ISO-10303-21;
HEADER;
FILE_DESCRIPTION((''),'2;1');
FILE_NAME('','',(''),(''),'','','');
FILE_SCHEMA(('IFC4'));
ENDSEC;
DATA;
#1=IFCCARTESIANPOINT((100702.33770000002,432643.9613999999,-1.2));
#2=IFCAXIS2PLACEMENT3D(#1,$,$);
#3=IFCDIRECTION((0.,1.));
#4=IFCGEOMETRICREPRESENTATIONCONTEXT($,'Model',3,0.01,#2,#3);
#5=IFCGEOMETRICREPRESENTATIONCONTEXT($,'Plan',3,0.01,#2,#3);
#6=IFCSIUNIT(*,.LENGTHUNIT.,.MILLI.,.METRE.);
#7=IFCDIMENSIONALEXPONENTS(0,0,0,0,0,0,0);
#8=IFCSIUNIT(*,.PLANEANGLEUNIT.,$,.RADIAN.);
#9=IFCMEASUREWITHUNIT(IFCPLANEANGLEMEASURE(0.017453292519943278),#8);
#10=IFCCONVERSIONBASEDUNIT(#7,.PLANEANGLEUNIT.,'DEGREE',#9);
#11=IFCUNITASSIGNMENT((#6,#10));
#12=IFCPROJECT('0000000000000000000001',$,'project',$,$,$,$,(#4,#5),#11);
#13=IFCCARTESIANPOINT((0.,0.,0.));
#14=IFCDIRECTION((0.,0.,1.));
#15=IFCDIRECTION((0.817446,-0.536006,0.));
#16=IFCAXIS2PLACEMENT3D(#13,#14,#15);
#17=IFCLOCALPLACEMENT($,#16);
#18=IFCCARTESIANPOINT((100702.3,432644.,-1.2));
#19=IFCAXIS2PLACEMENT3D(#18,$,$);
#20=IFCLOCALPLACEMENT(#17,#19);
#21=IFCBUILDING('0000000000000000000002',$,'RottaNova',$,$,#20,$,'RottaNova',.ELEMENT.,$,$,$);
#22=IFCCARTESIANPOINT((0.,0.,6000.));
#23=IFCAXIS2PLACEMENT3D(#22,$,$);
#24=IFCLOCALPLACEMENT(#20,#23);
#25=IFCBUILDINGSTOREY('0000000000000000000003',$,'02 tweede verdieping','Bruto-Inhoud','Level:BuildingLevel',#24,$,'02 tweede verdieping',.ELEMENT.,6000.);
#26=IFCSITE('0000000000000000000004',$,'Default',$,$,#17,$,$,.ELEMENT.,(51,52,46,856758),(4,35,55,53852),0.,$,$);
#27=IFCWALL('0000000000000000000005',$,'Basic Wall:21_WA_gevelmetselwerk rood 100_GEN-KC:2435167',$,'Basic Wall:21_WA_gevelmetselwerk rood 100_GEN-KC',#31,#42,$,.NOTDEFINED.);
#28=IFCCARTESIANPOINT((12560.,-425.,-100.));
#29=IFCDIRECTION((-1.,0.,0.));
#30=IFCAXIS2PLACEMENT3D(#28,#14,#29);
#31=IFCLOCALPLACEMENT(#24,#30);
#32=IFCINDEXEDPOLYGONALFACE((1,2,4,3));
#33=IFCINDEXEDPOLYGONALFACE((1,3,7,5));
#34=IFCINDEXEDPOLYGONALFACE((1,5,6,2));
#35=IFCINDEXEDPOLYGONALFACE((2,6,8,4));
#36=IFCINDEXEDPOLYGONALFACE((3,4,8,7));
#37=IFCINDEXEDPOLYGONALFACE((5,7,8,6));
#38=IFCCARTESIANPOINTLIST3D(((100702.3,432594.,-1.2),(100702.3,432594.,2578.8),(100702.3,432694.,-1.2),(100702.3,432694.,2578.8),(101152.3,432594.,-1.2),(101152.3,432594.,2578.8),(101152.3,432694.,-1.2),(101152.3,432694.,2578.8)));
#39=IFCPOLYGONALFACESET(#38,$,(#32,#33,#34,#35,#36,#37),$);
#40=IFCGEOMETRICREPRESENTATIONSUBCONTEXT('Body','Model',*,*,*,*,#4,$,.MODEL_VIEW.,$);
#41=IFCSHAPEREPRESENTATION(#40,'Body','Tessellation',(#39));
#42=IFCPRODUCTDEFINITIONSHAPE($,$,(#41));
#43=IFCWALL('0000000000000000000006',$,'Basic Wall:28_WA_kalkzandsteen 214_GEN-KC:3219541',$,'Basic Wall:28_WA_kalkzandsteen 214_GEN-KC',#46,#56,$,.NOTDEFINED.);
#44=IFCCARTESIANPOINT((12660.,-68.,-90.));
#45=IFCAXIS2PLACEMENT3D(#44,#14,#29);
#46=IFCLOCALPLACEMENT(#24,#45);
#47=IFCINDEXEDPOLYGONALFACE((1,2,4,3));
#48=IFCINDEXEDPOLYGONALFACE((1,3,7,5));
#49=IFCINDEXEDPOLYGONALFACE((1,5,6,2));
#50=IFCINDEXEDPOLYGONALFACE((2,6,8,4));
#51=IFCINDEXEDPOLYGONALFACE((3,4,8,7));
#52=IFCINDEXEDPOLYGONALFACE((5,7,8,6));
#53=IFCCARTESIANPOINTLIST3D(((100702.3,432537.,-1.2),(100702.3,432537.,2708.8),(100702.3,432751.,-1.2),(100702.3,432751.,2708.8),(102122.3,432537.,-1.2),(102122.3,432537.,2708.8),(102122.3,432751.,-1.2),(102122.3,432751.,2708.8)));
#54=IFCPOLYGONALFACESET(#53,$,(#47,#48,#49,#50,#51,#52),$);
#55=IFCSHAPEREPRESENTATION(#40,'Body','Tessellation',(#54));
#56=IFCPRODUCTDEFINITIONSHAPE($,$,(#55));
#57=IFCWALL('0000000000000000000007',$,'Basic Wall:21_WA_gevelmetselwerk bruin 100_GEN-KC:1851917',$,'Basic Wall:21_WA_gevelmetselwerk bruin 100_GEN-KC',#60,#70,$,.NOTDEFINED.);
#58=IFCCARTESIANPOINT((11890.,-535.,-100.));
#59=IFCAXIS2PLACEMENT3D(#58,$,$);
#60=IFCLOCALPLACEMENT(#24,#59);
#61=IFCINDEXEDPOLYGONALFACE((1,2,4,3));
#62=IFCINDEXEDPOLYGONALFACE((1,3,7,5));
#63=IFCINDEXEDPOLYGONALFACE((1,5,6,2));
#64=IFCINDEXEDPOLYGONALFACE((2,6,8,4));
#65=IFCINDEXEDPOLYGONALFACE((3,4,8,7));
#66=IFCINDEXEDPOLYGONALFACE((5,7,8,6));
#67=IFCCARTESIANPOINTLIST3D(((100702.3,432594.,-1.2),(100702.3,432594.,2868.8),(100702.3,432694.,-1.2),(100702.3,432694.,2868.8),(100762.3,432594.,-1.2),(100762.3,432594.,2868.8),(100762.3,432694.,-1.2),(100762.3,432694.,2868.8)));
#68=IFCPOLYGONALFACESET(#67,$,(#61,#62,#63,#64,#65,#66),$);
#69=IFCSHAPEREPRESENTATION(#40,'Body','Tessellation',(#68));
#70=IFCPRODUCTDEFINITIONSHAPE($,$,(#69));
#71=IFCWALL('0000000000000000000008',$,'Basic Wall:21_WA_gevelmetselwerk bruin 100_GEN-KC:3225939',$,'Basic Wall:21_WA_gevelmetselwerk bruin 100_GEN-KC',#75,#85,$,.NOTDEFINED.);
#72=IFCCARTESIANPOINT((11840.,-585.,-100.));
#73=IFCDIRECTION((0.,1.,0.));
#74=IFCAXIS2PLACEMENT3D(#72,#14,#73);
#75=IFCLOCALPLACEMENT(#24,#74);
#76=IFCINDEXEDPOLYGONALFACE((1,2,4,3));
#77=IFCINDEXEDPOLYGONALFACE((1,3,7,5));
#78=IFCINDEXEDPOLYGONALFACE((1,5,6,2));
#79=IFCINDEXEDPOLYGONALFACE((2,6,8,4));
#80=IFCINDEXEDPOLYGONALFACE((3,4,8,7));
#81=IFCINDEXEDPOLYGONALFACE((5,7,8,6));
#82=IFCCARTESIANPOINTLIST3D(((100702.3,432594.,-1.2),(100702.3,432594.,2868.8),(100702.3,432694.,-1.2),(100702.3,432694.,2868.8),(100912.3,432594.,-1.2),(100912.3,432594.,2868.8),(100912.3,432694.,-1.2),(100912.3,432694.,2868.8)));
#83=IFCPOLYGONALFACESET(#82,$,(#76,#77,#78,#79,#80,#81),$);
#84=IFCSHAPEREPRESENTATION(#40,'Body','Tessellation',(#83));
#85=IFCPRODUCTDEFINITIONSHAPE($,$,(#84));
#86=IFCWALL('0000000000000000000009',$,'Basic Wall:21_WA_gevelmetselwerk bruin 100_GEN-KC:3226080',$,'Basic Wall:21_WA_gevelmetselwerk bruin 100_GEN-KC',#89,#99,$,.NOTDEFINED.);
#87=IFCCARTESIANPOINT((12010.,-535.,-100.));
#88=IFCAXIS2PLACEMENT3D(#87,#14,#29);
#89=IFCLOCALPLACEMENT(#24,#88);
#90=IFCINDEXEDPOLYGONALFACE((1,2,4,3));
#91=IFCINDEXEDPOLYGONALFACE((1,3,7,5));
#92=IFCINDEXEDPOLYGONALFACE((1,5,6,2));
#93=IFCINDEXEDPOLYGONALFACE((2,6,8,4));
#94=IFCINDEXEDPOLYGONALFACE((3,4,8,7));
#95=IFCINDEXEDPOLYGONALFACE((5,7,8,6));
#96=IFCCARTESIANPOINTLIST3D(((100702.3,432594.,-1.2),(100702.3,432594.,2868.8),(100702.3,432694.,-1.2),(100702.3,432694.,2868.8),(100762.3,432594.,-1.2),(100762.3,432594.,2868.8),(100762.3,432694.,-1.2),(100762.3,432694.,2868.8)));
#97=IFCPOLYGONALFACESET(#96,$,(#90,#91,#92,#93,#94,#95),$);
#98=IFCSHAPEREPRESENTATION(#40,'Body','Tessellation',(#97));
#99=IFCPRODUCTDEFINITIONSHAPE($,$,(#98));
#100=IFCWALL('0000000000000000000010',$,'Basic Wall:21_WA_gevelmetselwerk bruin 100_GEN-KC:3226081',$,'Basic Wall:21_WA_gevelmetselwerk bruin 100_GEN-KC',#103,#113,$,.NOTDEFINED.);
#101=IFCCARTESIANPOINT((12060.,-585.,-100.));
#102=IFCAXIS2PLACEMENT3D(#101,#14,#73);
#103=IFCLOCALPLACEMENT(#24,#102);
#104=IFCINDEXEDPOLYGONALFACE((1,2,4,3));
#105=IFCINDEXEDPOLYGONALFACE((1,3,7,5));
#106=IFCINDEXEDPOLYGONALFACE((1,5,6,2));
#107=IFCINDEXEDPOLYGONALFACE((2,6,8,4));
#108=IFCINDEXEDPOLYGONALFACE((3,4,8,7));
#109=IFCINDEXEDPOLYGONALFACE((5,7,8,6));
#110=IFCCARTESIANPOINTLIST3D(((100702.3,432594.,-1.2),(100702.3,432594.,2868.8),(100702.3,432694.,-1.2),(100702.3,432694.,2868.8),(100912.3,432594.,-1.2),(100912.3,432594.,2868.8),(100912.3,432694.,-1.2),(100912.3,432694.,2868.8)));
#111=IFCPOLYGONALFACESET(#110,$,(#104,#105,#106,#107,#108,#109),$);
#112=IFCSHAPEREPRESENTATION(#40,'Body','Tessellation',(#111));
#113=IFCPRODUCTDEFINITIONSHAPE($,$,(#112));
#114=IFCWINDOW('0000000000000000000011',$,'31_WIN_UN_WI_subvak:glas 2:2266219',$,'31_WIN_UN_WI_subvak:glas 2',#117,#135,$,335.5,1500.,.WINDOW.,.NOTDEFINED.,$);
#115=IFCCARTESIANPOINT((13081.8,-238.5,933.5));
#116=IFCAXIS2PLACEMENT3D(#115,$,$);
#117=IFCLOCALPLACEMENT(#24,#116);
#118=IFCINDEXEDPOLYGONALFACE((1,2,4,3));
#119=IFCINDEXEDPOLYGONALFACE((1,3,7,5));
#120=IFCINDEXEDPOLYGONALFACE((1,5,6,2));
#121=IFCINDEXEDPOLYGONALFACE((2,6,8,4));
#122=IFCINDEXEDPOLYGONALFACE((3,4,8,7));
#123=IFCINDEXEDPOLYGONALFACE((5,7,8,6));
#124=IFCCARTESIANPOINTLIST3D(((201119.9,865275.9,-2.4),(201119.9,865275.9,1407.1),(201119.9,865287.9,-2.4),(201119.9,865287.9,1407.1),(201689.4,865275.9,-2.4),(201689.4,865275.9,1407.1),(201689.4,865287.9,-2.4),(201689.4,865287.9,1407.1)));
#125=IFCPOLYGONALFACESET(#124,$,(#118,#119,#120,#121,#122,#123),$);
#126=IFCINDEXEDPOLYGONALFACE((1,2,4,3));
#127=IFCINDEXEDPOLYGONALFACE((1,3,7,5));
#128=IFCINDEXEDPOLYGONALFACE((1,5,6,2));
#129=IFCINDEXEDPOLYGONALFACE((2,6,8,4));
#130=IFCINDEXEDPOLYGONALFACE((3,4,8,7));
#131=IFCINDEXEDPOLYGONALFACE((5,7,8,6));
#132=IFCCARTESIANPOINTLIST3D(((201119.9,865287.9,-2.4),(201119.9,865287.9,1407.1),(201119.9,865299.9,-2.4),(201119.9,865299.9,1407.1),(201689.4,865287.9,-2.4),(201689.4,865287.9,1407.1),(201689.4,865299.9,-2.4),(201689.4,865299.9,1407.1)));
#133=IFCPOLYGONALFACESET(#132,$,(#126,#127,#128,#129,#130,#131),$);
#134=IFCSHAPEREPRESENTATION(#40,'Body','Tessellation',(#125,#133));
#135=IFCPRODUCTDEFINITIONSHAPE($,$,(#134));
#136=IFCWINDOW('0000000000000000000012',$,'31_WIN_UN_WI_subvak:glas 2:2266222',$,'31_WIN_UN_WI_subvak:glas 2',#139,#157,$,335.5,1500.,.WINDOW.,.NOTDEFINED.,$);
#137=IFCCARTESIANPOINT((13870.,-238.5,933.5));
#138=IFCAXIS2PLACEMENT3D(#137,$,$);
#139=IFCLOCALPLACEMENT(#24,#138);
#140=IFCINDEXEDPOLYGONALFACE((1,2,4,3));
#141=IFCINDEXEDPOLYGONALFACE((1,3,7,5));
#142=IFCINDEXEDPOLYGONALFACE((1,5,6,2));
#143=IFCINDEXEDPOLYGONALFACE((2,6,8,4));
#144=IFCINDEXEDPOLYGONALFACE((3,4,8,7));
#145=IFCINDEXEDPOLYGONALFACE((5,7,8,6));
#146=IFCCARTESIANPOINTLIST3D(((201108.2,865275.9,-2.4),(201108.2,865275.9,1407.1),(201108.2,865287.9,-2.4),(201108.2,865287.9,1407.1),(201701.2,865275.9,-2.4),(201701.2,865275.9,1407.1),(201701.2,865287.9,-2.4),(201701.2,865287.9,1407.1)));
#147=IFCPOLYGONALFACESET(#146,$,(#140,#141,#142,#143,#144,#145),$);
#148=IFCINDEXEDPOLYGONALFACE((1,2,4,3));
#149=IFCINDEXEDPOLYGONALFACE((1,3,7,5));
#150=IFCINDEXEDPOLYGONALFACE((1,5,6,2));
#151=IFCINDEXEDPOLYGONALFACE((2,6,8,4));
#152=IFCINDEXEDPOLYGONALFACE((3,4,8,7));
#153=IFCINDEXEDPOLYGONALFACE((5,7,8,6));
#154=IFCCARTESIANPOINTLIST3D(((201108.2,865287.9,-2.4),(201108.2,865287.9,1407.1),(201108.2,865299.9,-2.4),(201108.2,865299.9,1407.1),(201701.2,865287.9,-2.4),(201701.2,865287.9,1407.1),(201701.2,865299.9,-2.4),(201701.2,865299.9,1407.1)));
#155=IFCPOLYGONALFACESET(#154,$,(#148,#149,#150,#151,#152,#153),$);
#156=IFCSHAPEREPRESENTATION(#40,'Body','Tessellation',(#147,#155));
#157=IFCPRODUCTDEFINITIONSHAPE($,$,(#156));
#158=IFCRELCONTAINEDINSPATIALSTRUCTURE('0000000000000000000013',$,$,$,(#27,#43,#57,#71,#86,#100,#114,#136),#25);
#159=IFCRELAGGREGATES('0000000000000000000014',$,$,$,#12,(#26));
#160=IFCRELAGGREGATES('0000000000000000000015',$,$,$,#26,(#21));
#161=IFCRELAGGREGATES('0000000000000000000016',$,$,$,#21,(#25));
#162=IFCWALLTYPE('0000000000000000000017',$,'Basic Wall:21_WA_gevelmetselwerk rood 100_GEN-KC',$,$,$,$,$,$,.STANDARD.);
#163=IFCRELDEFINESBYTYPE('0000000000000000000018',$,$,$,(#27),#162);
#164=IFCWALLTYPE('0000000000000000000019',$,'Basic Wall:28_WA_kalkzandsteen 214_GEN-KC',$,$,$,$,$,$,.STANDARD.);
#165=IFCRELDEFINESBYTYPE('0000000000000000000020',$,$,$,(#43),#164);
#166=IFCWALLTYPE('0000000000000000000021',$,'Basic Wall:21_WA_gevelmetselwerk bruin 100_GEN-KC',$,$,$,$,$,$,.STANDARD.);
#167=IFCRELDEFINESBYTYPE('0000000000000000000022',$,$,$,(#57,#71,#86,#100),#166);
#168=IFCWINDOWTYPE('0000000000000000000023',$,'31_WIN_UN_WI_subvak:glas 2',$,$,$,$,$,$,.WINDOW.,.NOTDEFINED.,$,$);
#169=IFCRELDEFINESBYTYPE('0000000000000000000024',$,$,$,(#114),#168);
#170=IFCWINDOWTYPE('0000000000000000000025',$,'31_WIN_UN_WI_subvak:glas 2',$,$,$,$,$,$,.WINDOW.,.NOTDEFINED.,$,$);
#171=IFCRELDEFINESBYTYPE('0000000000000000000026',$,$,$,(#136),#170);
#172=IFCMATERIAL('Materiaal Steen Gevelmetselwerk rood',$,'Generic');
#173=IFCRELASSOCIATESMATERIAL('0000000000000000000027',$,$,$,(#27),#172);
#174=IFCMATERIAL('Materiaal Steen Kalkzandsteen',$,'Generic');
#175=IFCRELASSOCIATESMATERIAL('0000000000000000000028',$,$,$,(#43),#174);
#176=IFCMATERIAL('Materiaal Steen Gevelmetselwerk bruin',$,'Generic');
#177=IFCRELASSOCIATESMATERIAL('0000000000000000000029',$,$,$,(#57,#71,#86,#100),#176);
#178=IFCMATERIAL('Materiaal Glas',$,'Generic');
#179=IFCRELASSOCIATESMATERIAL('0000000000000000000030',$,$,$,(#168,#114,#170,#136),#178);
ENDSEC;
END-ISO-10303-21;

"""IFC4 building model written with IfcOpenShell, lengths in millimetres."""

from ifc_helpers import new_model, entity, si_unit, converted_unit, direction, frame, place, context, subcontext, project, spatial, indexed_curve, outline, extrude, source, transform, mapped, material, type_object, type_shapes, element, save


model = new_model("IFC4")

# Units and contexts
model_context = context("Model", 3, precision=0.01, world=frame((100702.33770000002, 432643.9613999999, -1.2)), true_north=direction((0.0, 1.0)))
plan_context = context("Plan", 3, precision=0.01, world=frame((100702.33770000002, 432643.9613999999, -1.2)), true_north=direction((0.0, 1.0)))
body_context = subcontext(model_context, "Body", "Model", "MODEL_VIEW")
ifc_project = project(units=[si_unit("LENGTHUNIT", "METRE", prefix="MILLI"), converted_unit("PLANEANGLEUNIT", "DEGREE", entity("IfcPlaneAngleMeasure", 0.017453292519943278), si_unit("PLANEANGLEUNIT", "RADIAN"), dimensions=[0, 0, 0, 0, 0, 0, 0])], contexts=[model_context, plan_context])

# Site, building, storey
site_placement = place(None, frame((0.0, 0.0, 0.0), z_axis=(0.0, 0.0, 1.0), x_axis=(0.817446, -0.536006, 0.0)))
site = spatial("IfcSite", under=ifc_project, at=site_placement, Name="Default", CompositionType="ELEMENT", RefLatitude=(51, 52, 46, 856758), RefLongitude=(4, 35, 55, 53852), RefElevation=0.0)
building_placement = place(site_placement, frame((100702.3, 432644.0, -1.2)))
building = spatial("IfcBuilding", under=site, at=building_placement, Name="RottaNova", LongName="RottaNova", CompositionType="ELEMENT")
storey_placement = place(building_placement, frame((0.0, 0.0, 6000.0)))
storey = spatial("IfcBuildingStorey", under=building, at=storey_placement, Name="02 tweede verdieping", Description="Bruto-Inhoud", ObjectType="Level:BuildingLevel", LongName="02 tweede verdieping", CompositionType="ELEMENT", Elevation=6000.0)

# Shared definitions
ifc_material_1 = material(Name="Materiaal Glas", Category="Generic")

# Walls
ifc_material_2 = material(Name="Materiaal Steen Gevelmetselwerk rood", Category="Generic")
wall_type_1 = type_object("IfcWallType", Name="Basic Wall:21_WA_gevelmetselwerk rood 100_GEN-KC", PredefinedType="STANDARD")
wall_1_placement = place(storey_placement, frame((12560.0, -425.0, -100.0), z_axis=(0.0, 0.0, 1.0), x_axis=(-1.0, 0.0, 0.0)))
element("IfcWall", 1, at=wall_1_placement, inside=storey, type_object=wall_type_1, material=ifc_material_2, Name="Basic Wall:21_WA_gevelmetselwerk rood 100_GEN-KC:2435167", ObjectType="Basic Wall:21_WA_gevelmetselwerk rood 100_GEN-KC", PredefinedType="NOTDEFINED", context=body_context, shape_type="SweptSolid", body=[
    extrude(outline(indexed_curve([(450.0, 50.0), (0.0, 50.0), (0.0, -50.0), (450.0, -50.0), (450.0, 50.0)], self_intersect=False)), frame((100702.3, 432644.0, -1.2)), (0.0, 0.0, 1.0), 2580.0),
])
ifc_material_3 = material(Name="Materiaal Steen Kalkzandsteen", Category="Generic")
wall_type_2 = type_object("IfcWallType", Name="Basic Wall:28_WA_kalkzandsteen 214_GEN-KC", PredefinedType="STANDARD")
wall_2_placement = place(storey_placement, frame((12660.0, -68.0, -90.0), z_axis=(0.0, 0.0, 1.0), x_axis=(-1.0, 0.0, 0.0)))
element("IfcWall", 2, at=wall_2_placement, inside=storey, type_object=wall_type_2, material=ifc_material_3, Name="Basic Wall:28_WA_kalkzandsteen 214_GEN-KC:3219541", ObjectType="Basic Wall:28_WA_kalkzandsteen 214_GEN-KC", PredefinedType="NOTDEFINED", context=body_context, shape_type="SweptSolid", body=[
    extrude(outline(indexed_curve([(1420.0, 107.0), (0.0, 107.0), (0.0, -107.0), (1420.0, -107.0), (1420.0, 107.0)], self_intersect=False)), frame((100702.3, 432644.0, -1.2)), (0.0, 0.0, 1.0), 2710.0),
])
ifc_material_4 = material(Name="Materiaal Steen Gevelmetselwerk bruin", Category="Generic")
wall_type_3 = type_object("IfcWallType", Name="Basic Wall:21_WA_gevelmetselwerk bruin 100_GEN-KC", PredefinedType="STANDARD")
wall_3_placement = place(storey_placement, frame((11890.0, -535.0, -100.0)))
element("IfcWall", 3, at=wall_3_placement, inside=storey, type_object=wall_type_3, material=ifc_material_4, Name="Basic Wall:21_WA_gevelmetselwerk bruin 100_GEN-KC:1851917", ObjectType="Basic Wall:21_WA_gevelmetselwerk bruin 100_GEN-KC", PredefinedType="NOTDEFINED", context=body_context, shape_type="SweptSolid", body=[
    extrude(outline(indexed_curve([(60.0, 50.0), (0.0, 50.0), (0.0, -50.0), (60.0, -50.0), (60.0, 50.0)], self_intersect=False)), frame((100702.3, 432644.0, -1.2)), (0.0, 0.0, 1.0), 2870.0),
])
wall_4_placement = place(storey_placement, frame((11840.0, -585.0, -100.0), z_axis=(0.0, 0.0, 1.0), x_axis=(0.0, 1.0, 0.0)))
element("IfcWall", 4, at=wall_4_placement, inside=storey, type_object=wall_type_3, material=ifc_material_4, Name="Basic Wall:21_WA_gevelmetselwerk bruin 100_GEN-KC:3225939", ObjectType="Basic Wall:21_WA_gevelmetselwerk bruin 100_GEN-KC", PredefinedType="NOTDEFINED", context=body_context, shape_type="SweptSolid", body=[
    extrude(outline(indexed_curve([(210.0, 50.0), (0.0, 50.0), (0.0, -50.0), (210.0, -50.0), (210.0, 50.0)], self_intersect=False)), frame((100702.3, 432644.0, -1.2)), (0.0, 0.0, 1.0), 2870.0),
])
wall_5_placement = place(storey_placement, frame((12010.0, -535.0, -100.0), z_axis=(0.0, 0.0, 1.0), x_axis=(-1.0, 0.0, 0.0)))
element("IfcWall", 5, at=wall_5_placement, inside=storey, type_object=wall_type_3, material=ifc_material_4, Name="Basic Wall:21_WA_gevelmetselwerk bruin 100_GEN-KC:3226080", ObjectType="Basic Wall:21_WA_gevelmetselwerk bruin 100_GEN-KC", PredefinedType="NOTDEFINED", context=body_context, shape_type="SweptSolid", body=[
    extrude(outline(indexed_curve([(60.0, 50.0), (0.0, 50.0), (0.0, -50.0), (60.0, -50.0), (60.0, 50.0)], self_intersect=False)), frame((100702.3, 432644.0, -1.2)), (0.0, 0.0, 1.0), 2870.0),
])
wall_6_placement = place(storey_placement, frame((12060.0, -585.0, -100.0), z_axis=(0.0, 0.0, 1.0), x_axis=(0.0, 1.0, 0.0)))
element("IfcWall", 6, at=wall_6_placement, inside=storey, type_object=wall_type_3, material=ifc_material_4, Name="Basic Wall:21_WA_gevelmetselwerk bruin 100_GEN-KC:3226081", ObjectType="Basic Wall:21_WA_gevelmetselwerk bruin 100_GEN-KC", PredefinedType="NOTDEFINED", context=body_context, shape_type="SweptSolid", body=[
    extrude(outline(indexed_curve([(210.0, 50.0), (0.0, 50.0), (0.0, -50.0), (210.0, -50.0), (210.0, 50.0)], self_intersect=False)), frame((100702.3, 432644.0, -1.2)), (0.0, 0.0, 1.0), 2870.0),
])

# Windows
window_type_1 = type_object("IfcWindowType", Name="31_WIN_UN_WI_subvak:glas 2", PartitioningType="NOTDEFINED", PredefinedType="WINDOW", material=ifc_material_1)
shared_shape_1 = source(frame((100702.3, 432644.0, -1.2)), body_context, "Body", "SweptSolid", [
    extrude(outline(indexed_curve([(-284.7, -6.0), (284.7, -6.0), (284.7, 6.0), (-284.7, 6.0), (-284.7, -6.0)], self_intersect=False)), frame((0.0, -6.0, 0.0)), (0.0, 0.0, 1.0), 1409.5),
    extrude(outline(indexed_curve([(-284.8, -6.0), (284.8, -6.0), (284.8, 6.0), (-284.8, 6.0), (-284.8, -6.0)], self_intersect=False)), frame((0.0, 6.0, 0.0)), (0.0, 0.0, 1.0), 1409.5),
])
type_shapes(window_type_1, [shared_shape_1])
window_1_placement = place(storey_placement, frame((13081.8, -238.5, 933.5)))
element("IfcWindow", 7, at=window_1_placement, inside=storey, type_object=window_type_1, material=ifc_material_1, Name="31_WIN_UN_WI_subvak:glas 2:2266219", ObjectType="31_WIN_UN_WI_subvak:glas 2", OverallHeight=335.5, OverallWidth=1500.0, PartitioningType="NOTDEFINED", PredefinedType="WINDOW", context=body_context, shape_type="MappedRepresentation", body=[
    mapped(shared_shape_1, transform((100702.3, 432644.0, -1.2), scale=1.0)),
])
window_type_2 = type_object("IfcWindowType", Name="31_WIN_UN_WI_subvak:glas 2", PartitioningType="NOTDEFINED", PredefinedType="WINDOW", material=ifc_material_1)
shared_shape_2 = source(frame((100702.3, 432644.0, -1.2)), body_context, "Body", "SweptSolid", [
    extrude(outline(indexed_curve([(-296.5, -6.0), (296.5, -6.0), (296.5, 6.0), (-296.5, 6.0), (-296.5, -6.0)], self_intersect=False)), frame((0.0, -6.0, 0.0)), (0.0, 0.0, 1.0), 1409.5),
    extrude(outline(indexed_curve([(-296.5, -6.0), (296.5, -6.0), (296.5, 6.0), (-296.5, 6.0), (-296.5, -6.0)], self_intersect=False)), frame((0.0, 6.0, 0.0)), (0.0, 0.0, 1.0), 1409.5),
])
type_shapes(window_type_2, [shared_shape_2])
window_2_placement = place(storey_placement, frame((13870.0, -238.5, 933.5)))
element("IfcWindow", 8, at=window_2_placement, inside=storey, type_object=window_type_2, material=ifc_material_1, Name="31_WIN_UN_WI_subvak:glas 2:2266222", ObjectType="31_WIN_UN_WI_subvak:glas 2", OverallHeight=335.5, OverallWidth=1500.0, PartitioningType="NOTDEFINED", PredefinedType="WINDOW", context=body_context, shape_type="MappedRepresentation", body=[
    mapped(shared_shape_2, transform((100702.3, 432644.0, -1.2), scale=1.0)),
])

save(model, "model.ifc")
